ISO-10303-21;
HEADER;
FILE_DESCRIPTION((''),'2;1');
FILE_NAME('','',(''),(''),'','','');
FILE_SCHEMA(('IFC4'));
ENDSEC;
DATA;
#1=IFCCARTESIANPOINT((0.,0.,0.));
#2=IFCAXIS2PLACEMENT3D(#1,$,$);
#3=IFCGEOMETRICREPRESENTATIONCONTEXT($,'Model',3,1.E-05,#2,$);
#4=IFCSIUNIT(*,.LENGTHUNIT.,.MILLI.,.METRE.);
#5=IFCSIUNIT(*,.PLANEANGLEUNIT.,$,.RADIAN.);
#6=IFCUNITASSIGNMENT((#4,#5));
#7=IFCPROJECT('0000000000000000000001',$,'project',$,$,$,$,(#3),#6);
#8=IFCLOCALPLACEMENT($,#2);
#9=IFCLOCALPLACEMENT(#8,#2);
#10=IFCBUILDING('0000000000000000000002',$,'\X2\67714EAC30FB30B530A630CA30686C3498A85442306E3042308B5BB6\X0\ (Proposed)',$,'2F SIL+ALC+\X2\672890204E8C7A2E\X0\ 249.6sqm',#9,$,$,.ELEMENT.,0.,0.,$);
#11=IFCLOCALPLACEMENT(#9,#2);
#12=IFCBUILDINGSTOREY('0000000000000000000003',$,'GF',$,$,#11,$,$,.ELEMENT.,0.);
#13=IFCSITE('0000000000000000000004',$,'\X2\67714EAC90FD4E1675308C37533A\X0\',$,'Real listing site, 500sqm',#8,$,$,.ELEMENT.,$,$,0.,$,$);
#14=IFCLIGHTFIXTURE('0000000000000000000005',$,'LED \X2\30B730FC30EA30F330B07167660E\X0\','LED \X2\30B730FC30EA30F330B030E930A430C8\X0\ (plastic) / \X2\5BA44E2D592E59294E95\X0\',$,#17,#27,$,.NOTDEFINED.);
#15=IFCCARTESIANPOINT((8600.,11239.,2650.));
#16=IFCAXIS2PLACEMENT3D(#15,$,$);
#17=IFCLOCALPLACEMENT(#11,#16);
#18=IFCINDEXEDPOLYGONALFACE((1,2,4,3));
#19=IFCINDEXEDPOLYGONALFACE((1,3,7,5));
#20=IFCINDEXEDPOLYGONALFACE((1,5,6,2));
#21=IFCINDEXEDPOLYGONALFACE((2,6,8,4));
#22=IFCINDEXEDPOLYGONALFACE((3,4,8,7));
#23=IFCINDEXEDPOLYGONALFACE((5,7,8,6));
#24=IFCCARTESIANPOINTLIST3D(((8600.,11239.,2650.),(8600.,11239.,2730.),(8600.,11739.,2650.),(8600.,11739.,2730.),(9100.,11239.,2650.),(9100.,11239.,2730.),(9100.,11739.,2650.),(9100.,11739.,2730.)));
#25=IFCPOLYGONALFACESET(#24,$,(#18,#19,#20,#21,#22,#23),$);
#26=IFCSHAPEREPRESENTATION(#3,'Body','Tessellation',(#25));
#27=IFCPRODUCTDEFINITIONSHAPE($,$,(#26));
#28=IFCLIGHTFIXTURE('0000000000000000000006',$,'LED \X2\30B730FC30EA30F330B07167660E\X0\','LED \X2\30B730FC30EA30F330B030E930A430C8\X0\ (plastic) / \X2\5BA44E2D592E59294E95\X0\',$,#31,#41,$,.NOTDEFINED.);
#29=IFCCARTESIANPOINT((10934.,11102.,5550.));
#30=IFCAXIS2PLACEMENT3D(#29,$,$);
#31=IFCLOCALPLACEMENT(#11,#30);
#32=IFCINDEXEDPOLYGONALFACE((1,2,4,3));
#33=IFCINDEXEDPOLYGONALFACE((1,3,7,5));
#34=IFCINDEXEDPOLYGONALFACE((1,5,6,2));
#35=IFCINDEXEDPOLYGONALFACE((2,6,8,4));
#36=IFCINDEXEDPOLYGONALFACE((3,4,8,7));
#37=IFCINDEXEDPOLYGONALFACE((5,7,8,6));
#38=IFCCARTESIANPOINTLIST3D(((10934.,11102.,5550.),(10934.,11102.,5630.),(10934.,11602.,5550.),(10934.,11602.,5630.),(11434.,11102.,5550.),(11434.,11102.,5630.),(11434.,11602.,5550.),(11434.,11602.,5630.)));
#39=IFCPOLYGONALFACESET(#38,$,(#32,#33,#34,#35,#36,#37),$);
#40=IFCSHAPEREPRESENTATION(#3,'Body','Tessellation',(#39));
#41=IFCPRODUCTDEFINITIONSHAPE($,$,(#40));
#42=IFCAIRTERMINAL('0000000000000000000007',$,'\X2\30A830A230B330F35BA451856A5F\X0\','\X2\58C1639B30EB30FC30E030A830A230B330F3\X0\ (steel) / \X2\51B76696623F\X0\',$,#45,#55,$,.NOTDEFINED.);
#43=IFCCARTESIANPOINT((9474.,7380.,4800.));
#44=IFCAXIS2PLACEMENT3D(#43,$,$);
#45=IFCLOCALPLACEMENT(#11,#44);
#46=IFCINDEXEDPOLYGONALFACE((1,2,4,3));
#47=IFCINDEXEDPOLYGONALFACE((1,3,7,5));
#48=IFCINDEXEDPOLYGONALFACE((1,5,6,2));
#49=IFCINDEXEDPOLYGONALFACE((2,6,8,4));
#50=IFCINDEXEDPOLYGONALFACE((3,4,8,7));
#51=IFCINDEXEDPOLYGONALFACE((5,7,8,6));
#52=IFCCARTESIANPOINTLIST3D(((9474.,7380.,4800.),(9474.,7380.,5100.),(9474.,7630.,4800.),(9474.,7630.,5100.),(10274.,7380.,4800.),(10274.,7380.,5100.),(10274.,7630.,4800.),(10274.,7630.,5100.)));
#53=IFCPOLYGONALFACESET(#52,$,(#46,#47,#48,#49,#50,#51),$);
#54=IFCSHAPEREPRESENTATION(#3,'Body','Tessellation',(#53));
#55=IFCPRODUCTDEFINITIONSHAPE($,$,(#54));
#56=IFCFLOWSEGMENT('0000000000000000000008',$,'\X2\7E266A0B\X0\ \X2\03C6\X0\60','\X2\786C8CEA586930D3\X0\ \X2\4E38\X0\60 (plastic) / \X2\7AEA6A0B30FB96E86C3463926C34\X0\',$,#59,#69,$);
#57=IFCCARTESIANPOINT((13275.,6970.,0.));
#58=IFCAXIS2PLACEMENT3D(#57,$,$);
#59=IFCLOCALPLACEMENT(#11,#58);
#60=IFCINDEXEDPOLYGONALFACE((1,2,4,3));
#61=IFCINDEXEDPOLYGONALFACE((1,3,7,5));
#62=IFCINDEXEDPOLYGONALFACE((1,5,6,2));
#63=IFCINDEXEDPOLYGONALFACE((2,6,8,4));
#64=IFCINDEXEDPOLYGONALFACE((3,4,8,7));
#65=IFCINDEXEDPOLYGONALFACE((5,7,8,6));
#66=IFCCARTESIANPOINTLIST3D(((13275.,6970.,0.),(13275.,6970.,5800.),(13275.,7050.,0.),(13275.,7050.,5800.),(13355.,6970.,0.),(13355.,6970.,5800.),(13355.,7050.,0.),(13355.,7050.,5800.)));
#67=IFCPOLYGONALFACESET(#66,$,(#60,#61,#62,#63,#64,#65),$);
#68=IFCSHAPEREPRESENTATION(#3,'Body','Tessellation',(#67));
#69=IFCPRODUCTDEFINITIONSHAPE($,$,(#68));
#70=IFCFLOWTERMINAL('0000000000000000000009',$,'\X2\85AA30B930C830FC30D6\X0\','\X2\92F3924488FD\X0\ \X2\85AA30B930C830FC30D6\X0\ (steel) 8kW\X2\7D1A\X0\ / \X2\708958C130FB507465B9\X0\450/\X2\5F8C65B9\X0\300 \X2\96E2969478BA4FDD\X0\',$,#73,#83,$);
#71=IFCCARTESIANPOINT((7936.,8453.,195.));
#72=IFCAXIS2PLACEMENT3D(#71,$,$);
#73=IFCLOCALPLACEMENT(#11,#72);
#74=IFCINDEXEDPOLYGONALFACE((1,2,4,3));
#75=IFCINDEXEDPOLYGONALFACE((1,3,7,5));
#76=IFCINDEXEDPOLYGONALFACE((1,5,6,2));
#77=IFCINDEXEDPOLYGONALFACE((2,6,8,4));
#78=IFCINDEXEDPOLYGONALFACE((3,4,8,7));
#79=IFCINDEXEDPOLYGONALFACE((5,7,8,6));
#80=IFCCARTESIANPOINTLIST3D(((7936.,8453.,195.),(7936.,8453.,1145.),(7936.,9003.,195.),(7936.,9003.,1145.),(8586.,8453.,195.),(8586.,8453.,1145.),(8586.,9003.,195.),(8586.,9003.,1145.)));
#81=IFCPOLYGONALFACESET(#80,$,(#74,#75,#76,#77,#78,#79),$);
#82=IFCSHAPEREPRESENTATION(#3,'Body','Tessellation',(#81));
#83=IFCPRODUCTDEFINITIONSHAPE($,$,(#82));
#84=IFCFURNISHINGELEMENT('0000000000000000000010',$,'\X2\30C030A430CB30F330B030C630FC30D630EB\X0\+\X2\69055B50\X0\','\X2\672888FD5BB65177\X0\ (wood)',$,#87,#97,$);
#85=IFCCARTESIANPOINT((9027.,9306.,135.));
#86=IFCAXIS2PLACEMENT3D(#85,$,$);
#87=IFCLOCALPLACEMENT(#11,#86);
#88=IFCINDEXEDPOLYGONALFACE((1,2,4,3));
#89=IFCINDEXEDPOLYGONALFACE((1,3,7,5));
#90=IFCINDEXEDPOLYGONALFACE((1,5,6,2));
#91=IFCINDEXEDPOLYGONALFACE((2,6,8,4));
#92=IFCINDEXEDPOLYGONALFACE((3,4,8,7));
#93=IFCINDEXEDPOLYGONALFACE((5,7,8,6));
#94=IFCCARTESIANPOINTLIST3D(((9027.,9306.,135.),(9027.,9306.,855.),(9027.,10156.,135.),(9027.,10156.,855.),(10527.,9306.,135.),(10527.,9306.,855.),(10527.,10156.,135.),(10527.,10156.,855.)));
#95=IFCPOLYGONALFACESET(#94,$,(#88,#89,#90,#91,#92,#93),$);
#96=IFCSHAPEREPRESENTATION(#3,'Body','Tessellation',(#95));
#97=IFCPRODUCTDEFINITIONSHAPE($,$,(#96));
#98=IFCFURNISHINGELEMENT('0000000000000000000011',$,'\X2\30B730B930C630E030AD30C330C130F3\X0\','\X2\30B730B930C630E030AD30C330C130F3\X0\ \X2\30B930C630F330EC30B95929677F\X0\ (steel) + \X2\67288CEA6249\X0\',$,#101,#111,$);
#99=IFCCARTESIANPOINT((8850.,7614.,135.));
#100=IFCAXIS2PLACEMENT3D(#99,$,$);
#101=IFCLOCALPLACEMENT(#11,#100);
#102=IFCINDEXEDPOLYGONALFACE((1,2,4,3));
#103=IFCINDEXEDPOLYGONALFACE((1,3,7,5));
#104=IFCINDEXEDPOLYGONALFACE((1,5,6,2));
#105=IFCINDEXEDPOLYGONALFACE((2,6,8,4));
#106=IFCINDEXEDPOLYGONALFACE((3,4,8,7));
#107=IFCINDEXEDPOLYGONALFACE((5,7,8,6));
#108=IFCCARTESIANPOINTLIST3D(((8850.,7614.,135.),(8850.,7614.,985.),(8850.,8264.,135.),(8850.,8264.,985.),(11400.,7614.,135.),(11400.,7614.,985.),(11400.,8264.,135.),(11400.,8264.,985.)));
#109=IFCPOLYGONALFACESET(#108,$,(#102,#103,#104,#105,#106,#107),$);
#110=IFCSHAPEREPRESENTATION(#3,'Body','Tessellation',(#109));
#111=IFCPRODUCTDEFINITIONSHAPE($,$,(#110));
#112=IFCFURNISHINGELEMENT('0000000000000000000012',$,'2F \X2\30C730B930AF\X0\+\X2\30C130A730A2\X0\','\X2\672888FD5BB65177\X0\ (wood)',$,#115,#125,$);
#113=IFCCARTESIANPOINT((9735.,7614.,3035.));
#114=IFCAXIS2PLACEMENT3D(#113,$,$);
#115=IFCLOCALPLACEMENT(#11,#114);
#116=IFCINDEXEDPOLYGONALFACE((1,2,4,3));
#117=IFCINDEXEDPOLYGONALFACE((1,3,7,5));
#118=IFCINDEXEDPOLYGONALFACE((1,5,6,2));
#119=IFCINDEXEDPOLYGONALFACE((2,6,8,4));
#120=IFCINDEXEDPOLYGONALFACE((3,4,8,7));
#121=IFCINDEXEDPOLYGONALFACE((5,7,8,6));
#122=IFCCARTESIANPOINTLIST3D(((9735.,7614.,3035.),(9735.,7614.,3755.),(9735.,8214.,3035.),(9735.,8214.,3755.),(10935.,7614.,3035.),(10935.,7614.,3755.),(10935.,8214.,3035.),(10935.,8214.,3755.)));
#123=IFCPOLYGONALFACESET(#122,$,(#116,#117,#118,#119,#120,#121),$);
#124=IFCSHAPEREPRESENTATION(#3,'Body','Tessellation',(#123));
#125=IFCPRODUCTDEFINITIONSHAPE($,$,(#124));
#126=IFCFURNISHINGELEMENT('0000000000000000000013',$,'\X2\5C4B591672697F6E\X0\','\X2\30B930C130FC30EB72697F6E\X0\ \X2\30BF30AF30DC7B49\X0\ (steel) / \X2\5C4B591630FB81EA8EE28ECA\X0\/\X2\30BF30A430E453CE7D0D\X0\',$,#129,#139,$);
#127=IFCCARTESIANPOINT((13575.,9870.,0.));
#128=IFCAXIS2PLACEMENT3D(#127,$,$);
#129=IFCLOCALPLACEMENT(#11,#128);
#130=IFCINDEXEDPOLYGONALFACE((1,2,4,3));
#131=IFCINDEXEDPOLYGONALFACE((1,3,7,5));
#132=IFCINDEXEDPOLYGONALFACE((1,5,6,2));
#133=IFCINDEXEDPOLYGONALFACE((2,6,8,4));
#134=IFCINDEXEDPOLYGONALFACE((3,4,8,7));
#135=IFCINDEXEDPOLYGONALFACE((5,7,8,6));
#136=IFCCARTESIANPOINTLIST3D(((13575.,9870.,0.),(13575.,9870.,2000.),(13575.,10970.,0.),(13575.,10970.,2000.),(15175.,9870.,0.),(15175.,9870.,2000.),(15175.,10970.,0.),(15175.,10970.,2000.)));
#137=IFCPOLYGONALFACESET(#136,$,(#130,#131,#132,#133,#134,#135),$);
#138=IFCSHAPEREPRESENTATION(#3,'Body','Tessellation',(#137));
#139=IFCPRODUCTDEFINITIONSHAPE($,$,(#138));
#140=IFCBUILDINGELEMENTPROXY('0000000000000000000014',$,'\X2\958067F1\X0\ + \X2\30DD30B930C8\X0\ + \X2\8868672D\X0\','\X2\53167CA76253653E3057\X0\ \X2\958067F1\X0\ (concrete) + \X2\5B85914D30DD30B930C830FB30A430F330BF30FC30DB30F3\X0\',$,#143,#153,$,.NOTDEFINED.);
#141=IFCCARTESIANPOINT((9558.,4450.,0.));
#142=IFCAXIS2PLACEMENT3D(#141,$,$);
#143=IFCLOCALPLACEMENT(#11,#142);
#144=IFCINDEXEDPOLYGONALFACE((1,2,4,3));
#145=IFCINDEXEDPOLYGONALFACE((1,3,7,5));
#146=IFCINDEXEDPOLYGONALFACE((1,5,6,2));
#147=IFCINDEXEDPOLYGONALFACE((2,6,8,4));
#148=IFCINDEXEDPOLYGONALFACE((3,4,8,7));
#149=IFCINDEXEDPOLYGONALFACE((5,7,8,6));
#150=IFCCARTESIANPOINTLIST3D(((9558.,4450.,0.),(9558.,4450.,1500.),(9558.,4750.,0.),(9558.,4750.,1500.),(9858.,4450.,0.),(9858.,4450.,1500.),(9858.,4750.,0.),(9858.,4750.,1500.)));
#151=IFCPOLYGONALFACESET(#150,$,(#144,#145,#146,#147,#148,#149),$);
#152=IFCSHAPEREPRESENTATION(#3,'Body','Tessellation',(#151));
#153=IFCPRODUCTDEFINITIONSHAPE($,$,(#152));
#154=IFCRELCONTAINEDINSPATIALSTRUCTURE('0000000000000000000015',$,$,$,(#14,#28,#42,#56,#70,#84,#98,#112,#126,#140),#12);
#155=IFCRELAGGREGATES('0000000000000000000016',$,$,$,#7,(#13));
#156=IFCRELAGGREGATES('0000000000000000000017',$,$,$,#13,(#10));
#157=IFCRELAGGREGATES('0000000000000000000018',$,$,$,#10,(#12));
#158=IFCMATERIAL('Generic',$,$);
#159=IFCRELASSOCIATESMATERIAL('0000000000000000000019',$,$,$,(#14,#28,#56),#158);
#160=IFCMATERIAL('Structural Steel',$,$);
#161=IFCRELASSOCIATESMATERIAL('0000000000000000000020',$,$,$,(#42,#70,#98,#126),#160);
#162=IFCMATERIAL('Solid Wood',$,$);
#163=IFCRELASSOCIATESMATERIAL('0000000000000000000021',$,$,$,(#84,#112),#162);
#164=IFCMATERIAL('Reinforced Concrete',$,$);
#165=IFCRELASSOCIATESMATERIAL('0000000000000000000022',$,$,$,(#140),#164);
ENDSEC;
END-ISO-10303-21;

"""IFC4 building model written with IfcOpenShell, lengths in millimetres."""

from ifc_helpers import new_model, si_unit, frame, frame_2d, origin, place, context, project, spatial, rectangle, extrude, material, element, save


model = new_model("IFC4")

# Units and contexts
model_context = context("Model", 3, precision=1e-05, world=origin())
ifc_project = project(units=[si_unit("LENGTHUNIT", "METRE", prefix="MILLI"), si_unit("PLANEANGLEUNIT", "RADIAN")], contexts=[model_context])

# Site, building, storey
site_placement = place(None, origin())
site = spatial("IfcSite", under=ifc_project, at=site_placement, Name="東京都世田谷区", ObjectType="Real listing site, 500sqm", CompositionType="ELEMENT", RefElevation=0.0)
building_placement = place(site_placement, origin())
building = spatial("IfcBuilding", under=site, at=building_placement, Name="東京・サウナと水風呂のある家 (Proposed)", ObjectType="2F SIL+ALC+木造二種 249.6sqm", CompositionType="ELEMENT", ElevationOfRefHeight=0.0, ElevationOfTerrain=0.0)
storey_placement = place(building_placement, origin())
storey = spatial("IfcBuildingStorey", under=building, at=storey_placement, Name="GF", CompositionType="ELEMENT", Elevation=0.0)

# Shared definitions
ifc_material_1 = material(Name="Solid Wood")

# Shared definitions
ifc_material_2 = material(Name="Structural Steel")

# Shared definitions
ifc_material_3 = material(Name="Reinforced Concrete")

# Shared definitions
ifc_material_4 = material(Name="Generic")

# Light fixtures
light_fixture_1_placement = place(storey_placement, frame((8600.0, 11239.0, 2650.0)))
element("IfcLightFixture", 1, at=light_fixture_1_placement, inside=storey, material=ifc_material_4, Name="LED シーリング照明", Description="LED シーリングライト (plastic) / 室中央天井", PredefinedType="NOTDEFINED", context=model_context, shape_type="SweptSolid", body=[
    extrude(rectangle(XDim=500.0, YDim=500.0, at=frame_2d((250.0, 250.0))), frame((8600.0, 11239.0, 2650.0)), (0.0, 0.0, 1.0), 80.0),
])
light_fixture_2_placement = place(storey_placement, frame((10934.0, 11102.0, 5550.0)))
element("IfcLightFixture", 2, at=light_fixture_2_placement, inside=storey, material=ifc_material_4, Name="LED シーリング照明", Description="LED シーリングライト (plastic) / 室中央天井", PredefinedType="NOTDEFINED", context=model_context, shape_type="SweptSolid", body=[
    extrude(rectangle(XDim=500.0, YDim=500.0, at=frame_2d((250.0, 250.0))), frame((10934.0, 11102.0, 5550.0)), (0.0, 0.0, 1.0), 80.0),
])

# Air terminal
air_terminal_placement = place(storey_placement, frame((9474.0, 7380.0, 4800.0)))
element("IfcAirTerminal", 3, at=air_terminal_placement, inside=storey, material=ifc_material_2, Name="エアコン室内機", Description="壁掛ルームエアコン (steel) / 冷暖房", PredefinedType="NOTDEFINED", context=model_context, shape_type="SweptSolid", body=[
    extrude(rectangle(XDim=800.0, YDim=250.0, at=frame_2d((400.0, 125.0))), frame((9474.0, 7380.0, 4800.0)), (0.0, 0.0, 1.0), 300.0),
])

# Flow segment
flow_segment_placement = place(storey_placement, frame((13275.0, 6970.0, 0.0)))
element("IfcFlowSegment", 4, at=flow_segment_placement, inside=storey, material=ifc_material_4, Name="縦樋 φ60", Description="硬質塩ビ 丸60 (plastic) / 竪樋・雨水排水", context=model_context, shape_type="SweptSolid", body=[
    extrude(rectangle(XDim=80.0, YDim=80.0, at=frame_2d((40.0, 40.0))), frame((13275.0, 6970.0, 0.0)), (0.0, 0.0, 1.0), 5800.0),
])

# Flow terminal
flow_terminal_1_placement = place(storey_placement, frame((7936.0, 8453.0, 195.0)))
element("IfcFlowTerminal", 5, at=flow_terminal_1_placement, inside=storey, material=ifc_material_2, Name="薪ストーブ", Description="鋳鉄製 薪ストーブ (steel) 8kW級 / 炉壁・側方450/後方300 離隔確保", context=model_context, shape_type="SweptSolid", body=[
    extrude(rectangle(XDim=650.0, YDim=550.0, at=frame_2d((325.0, 275.0))), frame((7936.0, 8453.0, 195.0)), (0.0, 0.0, 1.0), 950.0),
])

# Furnishing elements
furnishing_1_placement = place(storey_placement, frame((9027.0, 9306.0, 135.0)))
element("IfcFurnishingElement", 6, at=furnishing_1_placement, inside=storey, material=ifc_material_1, Name="ダイニングテーブル+椅子", Description="木製家具 (wood)", context=model_context, shape_type="SweptSolid", body=[
    extrude(rectangle(XDim=1500.0, YDim=850.0, at=frame_2d((750.0, 425.0))), frame((9027.0, 9306.0, 135.0)), (0.0, 0.0, 1.0), 720.0),
])
furnishing_2_placement = place(storey_placement, frame((8850.0, 7614.0, 135.0)))
element("IfcFurnishingElement", 7, at=furnishing_2_placement, inside=storey, material=ifc_material_2, Name="システムキッチン", Description="システムキッチン ステンレス天板 (steel) + 木質扉", context=model_context, shape_type="SweptSolid", body=[
    extrude(rectangle(XDim=2550.0, YDim=650.0, at=frame_2d((1275.0, 325.0))), frame((8850.0, 7614.0, 135.0)), (0.0, 0.0, 1.0), 850.0),
])
furnishing_3_placement = place(storey_placement, frame((9735.0, 7614.0, 3035.0)))
element("IfcFurnishingElement", 8, at=furnishing_3_placement, inside=storey, material=ifc_material_1, Name="2F デスク+チェア", Description="木製家具 (wood)", context=model_context, shape_type="SweptSolid", body=[
    extrude(rectangle(XDim=1200.0, YDim=600.0, at=frame_2d((600.0, 300.0))), frame((9735.0, 7614.0, 3035.0)), (0.0, 0.0, 1.0), 720.0),
])
furnishing_4_placement = place(storey_placement, frame((13575.0, 9870.0, 0.0)))
element("IfcFurnishingElement", 9, at=furnishing_4_placement, inside=storey, material=ifc_material_2, Name="屋外物置", Description="スチール物置 タクボ等 (steel) / 屋外・自転車/タイヤ収納", context=model_context, shape_type="SweptSolid", body=[
    extrude(rectangle(XDim=1600.0, YDim=1100.0, at=frame_2d((800.0, 550.0))), frame((13575.0, 9870.0, 0.0)), (0.0, 0.0, 1.0), 2000.0),
])

# Building element proxy
proxy_placement = place(storey_placement, frame((9558.0, 4450.0, 0.0)))
element("IfcBuildingElementProxy", 10, at=proxy_placement, inside=storey, material=ifc_material_3, Name="門柱 + ポスト + 表札", Description="化粧打放し 門柱 (concrete) + 宅配ポスト・インターホン", PredefinedType="NOTDEFINED", context=model_context, shape_type="SweptSolid", body=[
    extrude(rectangle(XDim=300.0, YDim=300.0, at=frame_2d((150.0, 150.0))), frame((9558.0, 4450.0, 0.0)), (0.0, 0.0, 1.0), 1500.0),
])

save(model, "model.ifc")
